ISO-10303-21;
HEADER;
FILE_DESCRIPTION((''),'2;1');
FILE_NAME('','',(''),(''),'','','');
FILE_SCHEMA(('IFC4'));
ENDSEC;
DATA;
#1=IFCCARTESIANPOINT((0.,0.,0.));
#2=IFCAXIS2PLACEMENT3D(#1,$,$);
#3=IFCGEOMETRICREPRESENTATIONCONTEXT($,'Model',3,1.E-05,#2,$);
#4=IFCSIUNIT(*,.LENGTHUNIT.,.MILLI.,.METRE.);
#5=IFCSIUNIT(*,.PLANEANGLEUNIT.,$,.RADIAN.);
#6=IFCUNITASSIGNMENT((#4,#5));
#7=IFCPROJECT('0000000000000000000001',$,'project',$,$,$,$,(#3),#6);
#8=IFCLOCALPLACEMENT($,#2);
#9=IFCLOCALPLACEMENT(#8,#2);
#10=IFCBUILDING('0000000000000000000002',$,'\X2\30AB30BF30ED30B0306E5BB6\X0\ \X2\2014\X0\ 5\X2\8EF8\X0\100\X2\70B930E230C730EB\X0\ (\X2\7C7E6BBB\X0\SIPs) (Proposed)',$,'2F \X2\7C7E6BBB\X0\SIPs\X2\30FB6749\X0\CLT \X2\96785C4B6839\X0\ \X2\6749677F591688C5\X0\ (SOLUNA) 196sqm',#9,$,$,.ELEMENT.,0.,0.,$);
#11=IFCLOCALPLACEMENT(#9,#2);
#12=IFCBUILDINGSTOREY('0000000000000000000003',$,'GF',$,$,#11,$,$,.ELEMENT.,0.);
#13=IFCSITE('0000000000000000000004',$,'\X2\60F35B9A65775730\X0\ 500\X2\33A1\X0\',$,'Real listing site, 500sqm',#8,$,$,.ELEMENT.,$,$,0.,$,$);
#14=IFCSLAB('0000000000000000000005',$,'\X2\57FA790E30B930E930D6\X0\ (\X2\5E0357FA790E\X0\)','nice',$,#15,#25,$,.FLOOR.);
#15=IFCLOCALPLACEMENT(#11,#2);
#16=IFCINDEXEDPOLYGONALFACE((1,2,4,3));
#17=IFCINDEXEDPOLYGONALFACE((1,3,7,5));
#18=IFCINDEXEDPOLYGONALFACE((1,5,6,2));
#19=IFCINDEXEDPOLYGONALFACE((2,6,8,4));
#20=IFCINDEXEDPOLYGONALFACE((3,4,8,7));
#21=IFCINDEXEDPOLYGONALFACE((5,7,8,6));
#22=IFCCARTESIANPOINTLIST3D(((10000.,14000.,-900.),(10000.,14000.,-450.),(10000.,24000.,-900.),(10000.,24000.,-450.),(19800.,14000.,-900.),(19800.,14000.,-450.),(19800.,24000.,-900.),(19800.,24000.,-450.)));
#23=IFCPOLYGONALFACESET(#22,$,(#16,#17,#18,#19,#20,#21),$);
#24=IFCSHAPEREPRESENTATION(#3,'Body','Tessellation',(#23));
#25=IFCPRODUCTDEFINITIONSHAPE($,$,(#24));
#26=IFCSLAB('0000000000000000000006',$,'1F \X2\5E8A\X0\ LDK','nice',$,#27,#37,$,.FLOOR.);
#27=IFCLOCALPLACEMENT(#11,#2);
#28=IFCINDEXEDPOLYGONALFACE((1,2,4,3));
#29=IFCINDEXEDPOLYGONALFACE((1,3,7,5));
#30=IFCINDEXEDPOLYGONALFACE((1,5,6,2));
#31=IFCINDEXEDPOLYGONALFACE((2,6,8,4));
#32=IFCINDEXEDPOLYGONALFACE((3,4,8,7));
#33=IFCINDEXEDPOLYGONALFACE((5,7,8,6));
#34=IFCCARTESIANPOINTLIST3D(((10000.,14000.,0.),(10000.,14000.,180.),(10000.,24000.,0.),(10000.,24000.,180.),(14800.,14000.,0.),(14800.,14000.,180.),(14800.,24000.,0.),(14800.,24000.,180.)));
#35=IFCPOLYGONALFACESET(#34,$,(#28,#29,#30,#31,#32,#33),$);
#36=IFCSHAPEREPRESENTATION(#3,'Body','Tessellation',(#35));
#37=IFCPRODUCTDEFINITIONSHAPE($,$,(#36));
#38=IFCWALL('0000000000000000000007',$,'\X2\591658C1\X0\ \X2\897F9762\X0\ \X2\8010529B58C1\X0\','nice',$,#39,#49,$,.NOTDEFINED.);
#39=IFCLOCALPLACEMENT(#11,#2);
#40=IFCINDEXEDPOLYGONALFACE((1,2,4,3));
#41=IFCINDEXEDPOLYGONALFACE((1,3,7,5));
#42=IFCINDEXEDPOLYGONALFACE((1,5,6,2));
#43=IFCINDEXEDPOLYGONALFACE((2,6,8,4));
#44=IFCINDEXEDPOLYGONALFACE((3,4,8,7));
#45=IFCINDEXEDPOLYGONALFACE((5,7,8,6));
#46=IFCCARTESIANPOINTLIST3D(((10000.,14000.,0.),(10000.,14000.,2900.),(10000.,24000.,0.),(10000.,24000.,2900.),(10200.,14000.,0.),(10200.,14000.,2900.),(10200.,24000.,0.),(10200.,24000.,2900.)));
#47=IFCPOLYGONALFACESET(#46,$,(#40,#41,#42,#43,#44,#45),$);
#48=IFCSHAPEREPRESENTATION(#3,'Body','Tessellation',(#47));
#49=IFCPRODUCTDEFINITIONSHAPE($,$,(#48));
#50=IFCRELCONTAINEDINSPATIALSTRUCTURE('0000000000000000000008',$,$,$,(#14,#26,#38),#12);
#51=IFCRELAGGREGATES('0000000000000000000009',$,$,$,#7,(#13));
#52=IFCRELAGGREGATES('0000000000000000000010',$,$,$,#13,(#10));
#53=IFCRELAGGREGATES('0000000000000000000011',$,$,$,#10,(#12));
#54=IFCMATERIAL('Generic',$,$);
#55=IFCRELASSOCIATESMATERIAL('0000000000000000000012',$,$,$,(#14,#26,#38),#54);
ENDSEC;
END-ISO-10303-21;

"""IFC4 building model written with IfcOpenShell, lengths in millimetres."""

from ifc_helpers import new_model, si_unit, frame, frame_2d, origin, place, context, project, spatial, rectangle, extrude, material, element, save


model = new_model("IFC4")

# Units and contexts
model_context = context("Model", 3, precision=1e-05, world=origin())
ifc_project = project(units=[si_unit("LENGTHUNIT", "METRE", prefix="MILLI"), si_unit("PLANEANGLEUNIT", "RADIAN")], contexts=[model_context])

# Site, building, storey
site_placement = place(None, origin())
site = spatial("IfcSite", under=ifc_project, at=site_placement, Name="想定敷地 500㎡", ObjectType="Real listing site, 500sqm", CompositionType="ELEMENT", RefElevation=0.0)
building_placement = place(site_placement, origin())
building = spatial("IfcBuilding", under=site, at=building_placement, Name="カタログの家 — 5軸100点モデル (籾殻SIPs) (Proposed)", ObjectType="2F 籾殻SIPs・杉CLT 陸屋根 杉板外装 (SOLUNA) 196sqm", CompositionType="ELEMENT", ElevationOfRefHeight=0.0, ElevationOfTerrain=0.0)
storey_placement = place(building_placement, origin())
storey = spatial("IfcBuildingStorey", under=building, at=storey_placement, Name="GF", CompositionType="ELEMENT", Elevation=0.0)

# Slabs
ifc_material = material(Name="Generic")
slab_1_placement = place(storey_placement, frame((5000.0, 7000.0, -450.0)))
element("IfcSlab", 1, at=slab_1_placement, inside=storey, material=ifc_material, Name="基礎スラブ (布基礎)", Description="nice", PredefinedType="FLOOR", context=model_context, shape_type="SweptSolid", body=[
    extrude(rectangle(XDim=9800.0, YDim=10000.0, at=frame_2d((4900.0, 5000.0))), frame((5000.0, 7000.0, -450.0)), (0.0, 0.0, 1.0), 450.0),
])
slab_2_placement = place(storey_placement, frame((5000.0, 7000.0, 0.0)))
element("IfcSlab", 2, at=slab_2_placement, inside=storey, material=ifc_material, Name="1F 床 LDK", Description="nice", PredefinedType="FLOOR", context=model_context, shape_type="SweptSolid", body=[
    extrude(rectangle(XDim=4800.0, YDim=10000.0, at=frame_2d((2400.0, 5000.0))), frame((5000.0, 7000.0, 0.0)), (0.0, 0.0, 1.0), 180.0),
])

# Wall
wall_1_placement = place(storey_placement, frame((5000.0, 7000.0, 0.0)))
element("IfcWall", 3, at=wall_1_placement, inside=storey, material=ifc_material, Name="外壁 西面 耐力壁", Description="nice", PredefinedType="NOTDEFINED", context=model_context, shape_type="SweptSolid", body=[
    extrude(rectangle(XDim=200.0, YDim=10000.0, at=frame_2d((100.0, 5000.0))), frame((5000.0, 7000.0, 0.0)), (0.0, 0.0, 1.0), 2900.0),
])

save(model, "model.ifc")
